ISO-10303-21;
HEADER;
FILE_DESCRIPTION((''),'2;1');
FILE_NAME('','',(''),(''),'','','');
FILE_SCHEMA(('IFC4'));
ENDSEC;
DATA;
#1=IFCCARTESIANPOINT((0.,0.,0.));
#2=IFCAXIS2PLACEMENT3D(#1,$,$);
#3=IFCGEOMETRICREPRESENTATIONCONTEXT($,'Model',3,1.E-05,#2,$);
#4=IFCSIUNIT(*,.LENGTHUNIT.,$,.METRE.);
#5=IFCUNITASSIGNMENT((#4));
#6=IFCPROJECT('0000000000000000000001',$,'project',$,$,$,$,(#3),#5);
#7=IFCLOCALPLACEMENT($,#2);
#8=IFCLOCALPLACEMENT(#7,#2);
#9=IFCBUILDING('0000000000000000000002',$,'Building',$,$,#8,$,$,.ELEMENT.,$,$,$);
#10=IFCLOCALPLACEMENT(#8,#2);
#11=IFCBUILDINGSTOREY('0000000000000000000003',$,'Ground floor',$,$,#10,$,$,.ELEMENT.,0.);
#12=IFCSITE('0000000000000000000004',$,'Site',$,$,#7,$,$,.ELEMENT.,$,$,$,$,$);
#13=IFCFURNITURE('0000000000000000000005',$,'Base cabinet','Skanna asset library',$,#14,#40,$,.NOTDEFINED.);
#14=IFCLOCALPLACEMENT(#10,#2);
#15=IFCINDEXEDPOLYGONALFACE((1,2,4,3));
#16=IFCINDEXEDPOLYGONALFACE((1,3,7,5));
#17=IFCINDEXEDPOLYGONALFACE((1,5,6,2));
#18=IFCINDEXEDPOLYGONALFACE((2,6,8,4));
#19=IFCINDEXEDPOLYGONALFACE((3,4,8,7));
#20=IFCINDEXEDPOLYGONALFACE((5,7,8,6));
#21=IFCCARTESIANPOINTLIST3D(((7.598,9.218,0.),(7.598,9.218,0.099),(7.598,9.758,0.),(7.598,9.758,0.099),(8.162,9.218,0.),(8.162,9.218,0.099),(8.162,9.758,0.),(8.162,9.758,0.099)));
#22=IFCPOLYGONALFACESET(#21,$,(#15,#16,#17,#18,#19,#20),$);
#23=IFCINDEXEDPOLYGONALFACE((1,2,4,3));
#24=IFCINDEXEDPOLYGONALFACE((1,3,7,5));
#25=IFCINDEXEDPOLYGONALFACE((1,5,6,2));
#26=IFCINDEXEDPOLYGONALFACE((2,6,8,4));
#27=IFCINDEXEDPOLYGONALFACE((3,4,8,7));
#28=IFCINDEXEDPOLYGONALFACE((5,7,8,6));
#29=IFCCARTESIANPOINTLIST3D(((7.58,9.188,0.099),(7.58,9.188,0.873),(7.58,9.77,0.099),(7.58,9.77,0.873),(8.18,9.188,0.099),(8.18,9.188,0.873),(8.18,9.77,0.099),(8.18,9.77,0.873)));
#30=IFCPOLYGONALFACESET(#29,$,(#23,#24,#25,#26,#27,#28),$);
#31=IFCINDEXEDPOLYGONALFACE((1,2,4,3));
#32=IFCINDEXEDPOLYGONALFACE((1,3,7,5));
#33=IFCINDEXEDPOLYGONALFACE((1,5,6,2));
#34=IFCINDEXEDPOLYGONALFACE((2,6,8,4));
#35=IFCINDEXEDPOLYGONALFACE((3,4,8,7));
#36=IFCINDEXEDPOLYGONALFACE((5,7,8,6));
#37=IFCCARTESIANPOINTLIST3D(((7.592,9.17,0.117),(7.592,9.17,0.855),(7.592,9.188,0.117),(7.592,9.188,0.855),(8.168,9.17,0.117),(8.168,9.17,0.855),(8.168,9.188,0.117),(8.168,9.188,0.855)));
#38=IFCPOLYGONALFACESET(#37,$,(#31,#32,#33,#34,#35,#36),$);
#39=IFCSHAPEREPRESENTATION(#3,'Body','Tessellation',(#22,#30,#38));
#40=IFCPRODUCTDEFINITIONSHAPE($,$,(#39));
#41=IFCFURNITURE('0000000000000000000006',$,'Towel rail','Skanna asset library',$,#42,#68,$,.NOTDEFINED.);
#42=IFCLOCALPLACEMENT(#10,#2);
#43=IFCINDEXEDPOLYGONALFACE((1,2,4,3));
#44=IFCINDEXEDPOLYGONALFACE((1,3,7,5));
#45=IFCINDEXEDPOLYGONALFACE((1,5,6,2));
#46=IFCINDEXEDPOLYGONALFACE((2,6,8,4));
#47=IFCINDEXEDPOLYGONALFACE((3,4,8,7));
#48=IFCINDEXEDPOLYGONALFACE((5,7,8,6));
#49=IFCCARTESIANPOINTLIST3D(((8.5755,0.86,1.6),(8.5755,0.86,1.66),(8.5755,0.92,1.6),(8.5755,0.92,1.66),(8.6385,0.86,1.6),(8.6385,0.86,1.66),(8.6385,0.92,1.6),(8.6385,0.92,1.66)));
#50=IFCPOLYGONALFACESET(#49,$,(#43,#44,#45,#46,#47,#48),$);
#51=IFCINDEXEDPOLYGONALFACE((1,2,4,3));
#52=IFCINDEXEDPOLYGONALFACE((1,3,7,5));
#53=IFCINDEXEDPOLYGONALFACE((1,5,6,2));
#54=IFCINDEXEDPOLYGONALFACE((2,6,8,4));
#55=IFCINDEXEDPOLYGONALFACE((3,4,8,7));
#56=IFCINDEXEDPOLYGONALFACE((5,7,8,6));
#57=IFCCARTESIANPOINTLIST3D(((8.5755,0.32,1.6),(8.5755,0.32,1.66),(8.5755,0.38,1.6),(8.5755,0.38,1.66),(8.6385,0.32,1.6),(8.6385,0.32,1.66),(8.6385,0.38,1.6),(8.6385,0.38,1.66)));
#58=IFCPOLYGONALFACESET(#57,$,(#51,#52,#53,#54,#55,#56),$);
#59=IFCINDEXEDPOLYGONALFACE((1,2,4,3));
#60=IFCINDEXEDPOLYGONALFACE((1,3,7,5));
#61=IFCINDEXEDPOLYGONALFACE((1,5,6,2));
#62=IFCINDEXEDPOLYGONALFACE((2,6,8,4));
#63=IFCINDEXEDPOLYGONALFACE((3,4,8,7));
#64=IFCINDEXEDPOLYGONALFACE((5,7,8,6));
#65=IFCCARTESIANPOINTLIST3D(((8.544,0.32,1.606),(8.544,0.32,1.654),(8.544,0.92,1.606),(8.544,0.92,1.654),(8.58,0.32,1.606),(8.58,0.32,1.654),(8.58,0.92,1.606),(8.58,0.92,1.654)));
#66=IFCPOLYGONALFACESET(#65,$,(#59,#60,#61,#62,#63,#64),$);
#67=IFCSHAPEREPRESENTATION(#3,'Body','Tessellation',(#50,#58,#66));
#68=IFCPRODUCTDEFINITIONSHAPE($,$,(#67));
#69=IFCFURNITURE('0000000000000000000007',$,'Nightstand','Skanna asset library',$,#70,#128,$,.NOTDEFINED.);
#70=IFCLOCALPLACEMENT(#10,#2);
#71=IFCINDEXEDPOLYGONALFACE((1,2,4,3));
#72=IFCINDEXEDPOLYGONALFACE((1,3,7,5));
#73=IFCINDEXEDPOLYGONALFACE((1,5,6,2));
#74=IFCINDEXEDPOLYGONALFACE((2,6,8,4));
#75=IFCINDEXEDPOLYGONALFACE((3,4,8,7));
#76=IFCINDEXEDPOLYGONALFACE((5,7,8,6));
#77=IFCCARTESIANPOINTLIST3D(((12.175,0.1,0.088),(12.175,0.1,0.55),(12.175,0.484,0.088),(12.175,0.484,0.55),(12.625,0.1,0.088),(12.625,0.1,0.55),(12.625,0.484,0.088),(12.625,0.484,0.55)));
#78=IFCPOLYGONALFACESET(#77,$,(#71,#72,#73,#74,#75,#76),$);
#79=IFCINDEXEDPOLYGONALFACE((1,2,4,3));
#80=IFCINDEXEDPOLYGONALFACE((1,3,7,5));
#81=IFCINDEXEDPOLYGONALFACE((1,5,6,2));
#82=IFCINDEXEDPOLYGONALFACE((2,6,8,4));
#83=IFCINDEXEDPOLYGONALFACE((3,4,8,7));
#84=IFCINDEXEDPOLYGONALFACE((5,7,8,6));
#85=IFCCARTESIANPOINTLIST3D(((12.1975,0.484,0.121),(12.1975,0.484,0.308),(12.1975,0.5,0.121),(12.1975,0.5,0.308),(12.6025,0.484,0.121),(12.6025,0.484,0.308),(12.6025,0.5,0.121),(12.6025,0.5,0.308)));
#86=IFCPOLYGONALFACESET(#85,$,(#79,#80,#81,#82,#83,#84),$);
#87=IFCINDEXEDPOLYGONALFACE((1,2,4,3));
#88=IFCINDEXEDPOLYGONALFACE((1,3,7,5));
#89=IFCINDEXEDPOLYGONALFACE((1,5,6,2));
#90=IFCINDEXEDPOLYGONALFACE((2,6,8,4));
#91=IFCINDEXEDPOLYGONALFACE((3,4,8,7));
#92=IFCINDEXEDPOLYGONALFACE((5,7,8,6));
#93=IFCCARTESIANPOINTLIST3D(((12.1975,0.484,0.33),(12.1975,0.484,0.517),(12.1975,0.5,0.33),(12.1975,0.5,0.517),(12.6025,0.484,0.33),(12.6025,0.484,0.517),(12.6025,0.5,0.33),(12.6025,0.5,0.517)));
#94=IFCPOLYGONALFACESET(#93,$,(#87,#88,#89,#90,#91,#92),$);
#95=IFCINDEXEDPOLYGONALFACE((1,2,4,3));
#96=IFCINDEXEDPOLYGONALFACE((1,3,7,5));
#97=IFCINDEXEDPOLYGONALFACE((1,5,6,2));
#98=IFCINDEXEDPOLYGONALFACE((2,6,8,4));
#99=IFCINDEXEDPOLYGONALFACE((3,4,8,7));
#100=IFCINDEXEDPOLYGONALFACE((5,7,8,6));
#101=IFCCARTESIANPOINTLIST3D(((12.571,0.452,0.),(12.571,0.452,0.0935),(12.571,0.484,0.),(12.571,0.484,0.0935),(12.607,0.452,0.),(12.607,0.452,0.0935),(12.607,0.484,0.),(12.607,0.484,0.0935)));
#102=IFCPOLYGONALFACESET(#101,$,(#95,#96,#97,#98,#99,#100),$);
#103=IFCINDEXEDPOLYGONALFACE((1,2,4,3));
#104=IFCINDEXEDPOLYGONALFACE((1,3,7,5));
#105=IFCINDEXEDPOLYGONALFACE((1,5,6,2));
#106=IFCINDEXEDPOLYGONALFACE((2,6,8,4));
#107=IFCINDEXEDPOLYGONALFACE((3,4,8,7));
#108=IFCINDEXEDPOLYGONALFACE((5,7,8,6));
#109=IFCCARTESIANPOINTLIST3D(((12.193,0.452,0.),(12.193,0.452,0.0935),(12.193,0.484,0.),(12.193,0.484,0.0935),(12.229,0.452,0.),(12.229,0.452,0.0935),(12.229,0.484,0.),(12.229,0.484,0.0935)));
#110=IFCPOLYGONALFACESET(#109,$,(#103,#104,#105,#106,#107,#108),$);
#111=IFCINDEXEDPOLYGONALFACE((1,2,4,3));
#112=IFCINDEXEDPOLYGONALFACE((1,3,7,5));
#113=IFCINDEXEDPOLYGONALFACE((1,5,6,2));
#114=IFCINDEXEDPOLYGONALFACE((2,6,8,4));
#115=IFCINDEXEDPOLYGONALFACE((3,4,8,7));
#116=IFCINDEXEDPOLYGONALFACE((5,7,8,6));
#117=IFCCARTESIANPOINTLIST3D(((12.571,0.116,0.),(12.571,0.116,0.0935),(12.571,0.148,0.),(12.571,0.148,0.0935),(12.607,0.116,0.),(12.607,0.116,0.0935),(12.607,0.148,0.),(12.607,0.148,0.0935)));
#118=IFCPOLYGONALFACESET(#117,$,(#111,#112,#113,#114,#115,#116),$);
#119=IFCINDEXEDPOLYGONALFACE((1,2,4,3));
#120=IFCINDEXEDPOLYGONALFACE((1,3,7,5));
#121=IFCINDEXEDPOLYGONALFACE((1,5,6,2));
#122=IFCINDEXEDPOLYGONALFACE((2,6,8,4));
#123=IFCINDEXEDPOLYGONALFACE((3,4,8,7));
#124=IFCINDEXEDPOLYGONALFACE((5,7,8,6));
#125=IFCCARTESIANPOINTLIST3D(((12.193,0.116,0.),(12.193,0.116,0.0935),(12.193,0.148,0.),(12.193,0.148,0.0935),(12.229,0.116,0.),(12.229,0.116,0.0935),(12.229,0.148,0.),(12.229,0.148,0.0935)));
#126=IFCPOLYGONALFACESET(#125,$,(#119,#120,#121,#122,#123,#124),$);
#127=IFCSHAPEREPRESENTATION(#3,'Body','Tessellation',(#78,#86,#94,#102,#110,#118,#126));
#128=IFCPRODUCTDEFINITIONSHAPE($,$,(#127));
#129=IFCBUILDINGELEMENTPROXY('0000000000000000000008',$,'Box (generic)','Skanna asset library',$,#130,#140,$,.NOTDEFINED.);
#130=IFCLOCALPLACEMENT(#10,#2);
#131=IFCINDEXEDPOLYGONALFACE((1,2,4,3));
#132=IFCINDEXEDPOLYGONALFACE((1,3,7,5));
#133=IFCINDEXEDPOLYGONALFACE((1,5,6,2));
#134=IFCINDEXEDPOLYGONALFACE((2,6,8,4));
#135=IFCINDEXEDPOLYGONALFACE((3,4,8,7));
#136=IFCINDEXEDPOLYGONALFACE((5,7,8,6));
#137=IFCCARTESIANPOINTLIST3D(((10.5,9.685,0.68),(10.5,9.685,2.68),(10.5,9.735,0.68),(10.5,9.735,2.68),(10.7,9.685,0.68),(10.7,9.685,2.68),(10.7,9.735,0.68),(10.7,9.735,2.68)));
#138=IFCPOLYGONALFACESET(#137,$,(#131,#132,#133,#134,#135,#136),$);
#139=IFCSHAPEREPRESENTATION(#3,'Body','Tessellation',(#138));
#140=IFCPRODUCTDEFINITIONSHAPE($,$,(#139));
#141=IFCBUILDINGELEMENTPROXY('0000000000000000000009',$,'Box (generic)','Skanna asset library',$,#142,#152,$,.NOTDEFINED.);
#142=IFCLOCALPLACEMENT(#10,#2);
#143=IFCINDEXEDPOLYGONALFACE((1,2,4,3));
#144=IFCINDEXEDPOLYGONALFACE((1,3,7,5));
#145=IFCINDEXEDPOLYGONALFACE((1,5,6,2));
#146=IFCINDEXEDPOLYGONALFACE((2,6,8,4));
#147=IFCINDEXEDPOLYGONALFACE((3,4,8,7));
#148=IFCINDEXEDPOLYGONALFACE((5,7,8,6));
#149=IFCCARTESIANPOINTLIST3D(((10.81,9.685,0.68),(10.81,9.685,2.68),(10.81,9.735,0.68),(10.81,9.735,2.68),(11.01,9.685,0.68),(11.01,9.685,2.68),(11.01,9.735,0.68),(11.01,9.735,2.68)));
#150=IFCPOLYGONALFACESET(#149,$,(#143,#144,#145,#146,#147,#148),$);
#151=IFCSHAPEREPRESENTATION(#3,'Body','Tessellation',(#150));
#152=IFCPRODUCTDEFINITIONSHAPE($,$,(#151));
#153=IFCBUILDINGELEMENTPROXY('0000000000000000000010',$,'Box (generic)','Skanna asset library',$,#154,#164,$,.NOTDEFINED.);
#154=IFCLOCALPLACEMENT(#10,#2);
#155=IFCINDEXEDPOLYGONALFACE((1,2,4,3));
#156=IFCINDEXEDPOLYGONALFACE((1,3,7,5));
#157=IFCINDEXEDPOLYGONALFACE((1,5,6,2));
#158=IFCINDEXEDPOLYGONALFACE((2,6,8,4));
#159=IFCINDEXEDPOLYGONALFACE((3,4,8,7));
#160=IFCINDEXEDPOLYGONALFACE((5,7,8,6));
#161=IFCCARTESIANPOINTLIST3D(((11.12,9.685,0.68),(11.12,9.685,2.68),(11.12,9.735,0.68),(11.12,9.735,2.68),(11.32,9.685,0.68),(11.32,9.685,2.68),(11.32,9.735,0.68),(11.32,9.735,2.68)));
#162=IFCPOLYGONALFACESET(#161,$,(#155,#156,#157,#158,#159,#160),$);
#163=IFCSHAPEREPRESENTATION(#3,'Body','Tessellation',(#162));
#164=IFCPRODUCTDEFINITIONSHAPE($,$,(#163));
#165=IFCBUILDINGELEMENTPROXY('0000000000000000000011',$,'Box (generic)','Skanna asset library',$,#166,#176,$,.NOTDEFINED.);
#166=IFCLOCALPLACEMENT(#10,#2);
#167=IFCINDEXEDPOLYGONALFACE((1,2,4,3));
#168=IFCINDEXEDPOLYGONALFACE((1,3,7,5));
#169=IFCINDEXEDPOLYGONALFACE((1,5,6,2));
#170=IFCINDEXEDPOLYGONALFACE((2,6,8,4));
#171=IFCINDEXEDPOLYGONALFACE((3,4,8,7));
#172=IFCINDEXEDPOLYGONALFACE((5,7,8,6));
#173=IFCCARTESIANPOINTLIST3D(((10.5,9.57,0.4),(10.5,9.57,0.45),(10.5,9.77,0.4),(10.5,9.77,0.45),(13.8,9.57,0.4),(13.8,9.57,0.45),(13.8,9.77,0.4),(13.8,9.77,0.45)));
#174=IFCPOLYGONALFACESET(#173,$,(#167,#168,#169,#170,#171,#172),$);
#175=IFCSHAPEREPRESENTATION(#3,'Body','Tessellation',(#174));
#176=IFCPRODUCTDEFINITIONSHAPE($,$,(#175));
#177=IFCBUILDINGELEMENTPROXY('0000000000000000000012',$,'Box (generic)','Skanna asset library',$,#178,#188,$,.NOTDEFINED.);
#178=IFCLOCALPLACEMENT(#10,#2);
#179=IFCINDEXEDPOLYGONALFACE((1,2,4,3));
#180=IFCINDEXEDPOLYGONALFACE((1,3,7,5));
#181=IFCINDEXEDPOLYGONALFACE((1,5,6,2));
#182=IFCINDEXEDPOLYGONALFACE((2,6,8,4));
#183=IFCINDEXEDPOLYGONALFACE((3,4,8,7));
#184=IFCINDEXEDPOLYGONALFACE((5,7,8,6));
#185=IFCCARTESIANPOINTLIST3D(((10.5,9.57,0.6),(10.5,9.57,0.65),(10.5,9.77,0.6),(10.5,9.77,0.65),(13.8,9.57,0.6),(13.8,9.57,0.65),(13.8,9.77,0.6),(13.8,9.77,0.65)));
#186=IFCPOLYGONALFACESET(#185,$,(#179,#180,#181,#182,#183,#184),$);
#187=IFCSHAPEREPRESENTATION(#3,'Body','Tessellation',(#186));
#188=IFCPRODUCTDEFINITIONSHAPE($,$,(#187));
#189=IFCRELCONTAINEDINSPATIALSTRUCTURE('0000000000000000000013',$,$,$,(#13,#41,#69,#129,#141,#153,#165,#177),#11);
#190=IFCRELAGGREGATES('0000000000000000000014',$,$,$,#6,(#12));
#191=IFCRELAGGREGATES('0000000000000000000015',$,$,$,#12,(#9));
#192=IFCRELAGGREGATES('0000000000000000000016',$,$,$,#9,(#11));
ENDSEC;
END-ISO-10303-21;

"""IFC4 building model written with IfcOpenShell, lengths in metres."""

from ifc_helpers import new_model, si_unit, frame, frame_2d, origin, origin_2d, place, context, project, spatial, rectangle, extrude, element, save


model = new_model("IFC4")

# Units and contexts
model_context = context("Model", 3, precision=1e-05, world=origin())
ifc_project = project(units=[si_unit("LENGTHUNIT", "METRE")], contexts=[model_context])

# Site, building, storey
site_placement = place(None, origin())
site = spatial("IfcSite", under=ifc_project, at=site_placement, Name="Site", CompositionType="ELEMENT")
building_placement = place(site_placement, origin())
building = spatial("IfcBuilding", under=site, at=building_placement, Name="Building", CompositionType="ELEMENT")
storey_placement = place(building_placement, origin())
storey = spatial("IfcBuildingStorey", under=building, at=storey_placement, Name="Ground floor", CompositionType="ELEMENT", Elevation=0.0)

# Furniture
furniture_1_placement = place(storey_placement, frame((7.88, 9.47, 0.0), z_axis=(0.0, 0.0, 1.0), x_axis=(1.0, 0.0, 0.0)))
element("IfcFurniture", 1, at=furniture_1_placement, inside=storey, Name="Base cabinet", Description="Skanna asset library", PredefinedType="NOTDEFINED", context=model_context, shape_type="SweptSolid", body=[
    extrude(rectangle(XDim=0.564, YDim=0.54, at=frame_2d((0.0, 0.018))), origin(), (0.0, 0.0, 1.0), 0.099),
    extrude(rectangle(XDim=0.6, YDim=0.582, at=frame_2d((0.0, 0.009))), frame((0.0, 0.0, 0.099)), (0.0, 0.0, 1.0), 0.774),
    extrude(rectangle(XDim=0.576, YDim=0.018, at=frame_2d((0.0, -0.291))), frame((0.0, 0.0, 0.117)), (0.0, 0.0, 1.0), 0.738),
])
furniture_2_placement = place(storey_placement, frame((8.58, 0.62, 1.6), z_axis=(0.0, 0.0, 1.0), x_axis=(0.0, -1.0, 0.0)))
element("IfcFurniture", 2, at=furniture_2_placement, inside=storey, Name="Towel rail", Description="Skanna asset library", PredefinedType="NOTDEFINED", context=model_context, shape_type="SweptSolid", body=[
    extrude(rectangle(XDim=0.06, YDim=0.063, at=frame_2d((-0.27, 0.027))), origin(), (0.0, 0.0, 1.0), 0.06),
    extrude(rectangle(XDim=0.06, YDim=0.063, at=frame_2d((0.27, 0.027))), origin(), (0.0, 0.0, 1.0), 0.06),
    extrude(rectangle(XDim=0.6, YDim=0.036, at=frame_2d((0.0, -0.018))), frame((0.0, 0.0, 0.006)), (0.0, 0.0, 1.0), 0.048),
])
furniture_3_placement = place(storey_placement, frame((12.4, 0.3, 0.0), z_axis=(0.0, 0.0, 1.0), x_axis=(-1.0, 0.0, 0.0)))
element("IfcFurniture", 3, at=furniture_3_placement, inside=storey, Name="Nightstand", Description="Skanna asset library", PredefinedType="NOTDEFINED", context=model_context, shape_type="SweptSolid", body=[
    extrude(rectangle(XDim=0.45, YDim=0.384, at=frame_2d((0.0, 0.008))), frame((0.0, 0.0, 0.088)), (0.0, 0.0, 1.0), 0.462),
    extrude(rectangle(XDim=0.405, YDim=0.016, at=frame_2d((0.0, -0.192))), frame((0.0, 0.0, 0.121)), (0.0, 0.0, 1.0), 0.187),
    extrude(rectangle(XDim=0.405, YDim=0.016, at=frame_2d((0.0, -0.192))), frame((0.0, 0.0, 0.33)), (0.0, 0.0, 1.0), 0.187),
    extrude(rectangle(XDim=0.036, YDim=0.032, at=frame_2d((-0.189, -0.168))), origin(), (0.0, 0.0, 1.0), 0.0935),
    extrude(rectangle(XDim=0.036, YDim=0.032, at=frame_2d((0.189, -0.168))), origin(), (0.0, 0.0, 1.0), 0.0935),
    extrude(rectangle(XDim=0.036, YDim=0.032, at=frame_2d((-0.189, 0.168))), origin(), (0.0, 0.0, 1.0), 0.0935),
    extrude(rectangle(XDim=0.036, YDim=0.032, at=frame_2d((0.189, 0.168))), origin(), (0.0, 0.0, 1.0), 0.0935),
])

# Building element proxies
for number, where, z_axis, x_axis, name in (
    (4, (10.6, 9.71, 0.68), (0.0, 0.0, 1.0), (1.0, 0.0, 0.0), "Box (generic)"),
    (5, (10.91, 9.71, 0.68), (0.0, 0.0, 1.0), (1.0, 0.0, 0.0), "Box (generic)"),
    (6, (11.22, 9.71, 0.68), (0.0, 0.0, 1.0), (1.0, 0.0, 0.0), "Box (generic)"),
):
    element("IfcBuildingElementProxy", number, at=place(storey_placement, frame(where, z_axis=z_axis, x_axis=x_axis)), inside=storey, Name=name, Description="Skanna asset library", PredefinedType="NOTDEFINED", context=model_context, shape_type="SweptSolid", body=[
        extrude(rectangle(XDim=0.2, YDim=0.05, at=origin_2d()), origin(), (0.0, 0.0, 1.0), 2.0),
    ])
for number, where, z_axis, x_axis, name in (
    (7, (12.15, 9.67, 0.4), (0.0, 0.0, 1.0), (1.0, 0.0, 0.0), "Box (generic)"),
    (8, (12.15, 9.67, 0.6), (0.0, 0.0, 1.0), (1.0, 0.0, 0.0), "Box (generic)"),
):
    element("IfcBuildingElementProxy", number, at=place(storey_placement, frame(where, z_axis=z_axis, x_axis=x_axis)), inside=storey, Name=name, Description="Skanna asset library", PredefinedType="NOTDEFINED", context=model_context, shape_type="SweptSolid", body=[
        extrude(rectangle(XDim=3.3, YDim=0.2, at=origin_2d()), origin(), (0.0, 0.0, 1.0), 0.05),
    ])

save(model, "model.ifc")
